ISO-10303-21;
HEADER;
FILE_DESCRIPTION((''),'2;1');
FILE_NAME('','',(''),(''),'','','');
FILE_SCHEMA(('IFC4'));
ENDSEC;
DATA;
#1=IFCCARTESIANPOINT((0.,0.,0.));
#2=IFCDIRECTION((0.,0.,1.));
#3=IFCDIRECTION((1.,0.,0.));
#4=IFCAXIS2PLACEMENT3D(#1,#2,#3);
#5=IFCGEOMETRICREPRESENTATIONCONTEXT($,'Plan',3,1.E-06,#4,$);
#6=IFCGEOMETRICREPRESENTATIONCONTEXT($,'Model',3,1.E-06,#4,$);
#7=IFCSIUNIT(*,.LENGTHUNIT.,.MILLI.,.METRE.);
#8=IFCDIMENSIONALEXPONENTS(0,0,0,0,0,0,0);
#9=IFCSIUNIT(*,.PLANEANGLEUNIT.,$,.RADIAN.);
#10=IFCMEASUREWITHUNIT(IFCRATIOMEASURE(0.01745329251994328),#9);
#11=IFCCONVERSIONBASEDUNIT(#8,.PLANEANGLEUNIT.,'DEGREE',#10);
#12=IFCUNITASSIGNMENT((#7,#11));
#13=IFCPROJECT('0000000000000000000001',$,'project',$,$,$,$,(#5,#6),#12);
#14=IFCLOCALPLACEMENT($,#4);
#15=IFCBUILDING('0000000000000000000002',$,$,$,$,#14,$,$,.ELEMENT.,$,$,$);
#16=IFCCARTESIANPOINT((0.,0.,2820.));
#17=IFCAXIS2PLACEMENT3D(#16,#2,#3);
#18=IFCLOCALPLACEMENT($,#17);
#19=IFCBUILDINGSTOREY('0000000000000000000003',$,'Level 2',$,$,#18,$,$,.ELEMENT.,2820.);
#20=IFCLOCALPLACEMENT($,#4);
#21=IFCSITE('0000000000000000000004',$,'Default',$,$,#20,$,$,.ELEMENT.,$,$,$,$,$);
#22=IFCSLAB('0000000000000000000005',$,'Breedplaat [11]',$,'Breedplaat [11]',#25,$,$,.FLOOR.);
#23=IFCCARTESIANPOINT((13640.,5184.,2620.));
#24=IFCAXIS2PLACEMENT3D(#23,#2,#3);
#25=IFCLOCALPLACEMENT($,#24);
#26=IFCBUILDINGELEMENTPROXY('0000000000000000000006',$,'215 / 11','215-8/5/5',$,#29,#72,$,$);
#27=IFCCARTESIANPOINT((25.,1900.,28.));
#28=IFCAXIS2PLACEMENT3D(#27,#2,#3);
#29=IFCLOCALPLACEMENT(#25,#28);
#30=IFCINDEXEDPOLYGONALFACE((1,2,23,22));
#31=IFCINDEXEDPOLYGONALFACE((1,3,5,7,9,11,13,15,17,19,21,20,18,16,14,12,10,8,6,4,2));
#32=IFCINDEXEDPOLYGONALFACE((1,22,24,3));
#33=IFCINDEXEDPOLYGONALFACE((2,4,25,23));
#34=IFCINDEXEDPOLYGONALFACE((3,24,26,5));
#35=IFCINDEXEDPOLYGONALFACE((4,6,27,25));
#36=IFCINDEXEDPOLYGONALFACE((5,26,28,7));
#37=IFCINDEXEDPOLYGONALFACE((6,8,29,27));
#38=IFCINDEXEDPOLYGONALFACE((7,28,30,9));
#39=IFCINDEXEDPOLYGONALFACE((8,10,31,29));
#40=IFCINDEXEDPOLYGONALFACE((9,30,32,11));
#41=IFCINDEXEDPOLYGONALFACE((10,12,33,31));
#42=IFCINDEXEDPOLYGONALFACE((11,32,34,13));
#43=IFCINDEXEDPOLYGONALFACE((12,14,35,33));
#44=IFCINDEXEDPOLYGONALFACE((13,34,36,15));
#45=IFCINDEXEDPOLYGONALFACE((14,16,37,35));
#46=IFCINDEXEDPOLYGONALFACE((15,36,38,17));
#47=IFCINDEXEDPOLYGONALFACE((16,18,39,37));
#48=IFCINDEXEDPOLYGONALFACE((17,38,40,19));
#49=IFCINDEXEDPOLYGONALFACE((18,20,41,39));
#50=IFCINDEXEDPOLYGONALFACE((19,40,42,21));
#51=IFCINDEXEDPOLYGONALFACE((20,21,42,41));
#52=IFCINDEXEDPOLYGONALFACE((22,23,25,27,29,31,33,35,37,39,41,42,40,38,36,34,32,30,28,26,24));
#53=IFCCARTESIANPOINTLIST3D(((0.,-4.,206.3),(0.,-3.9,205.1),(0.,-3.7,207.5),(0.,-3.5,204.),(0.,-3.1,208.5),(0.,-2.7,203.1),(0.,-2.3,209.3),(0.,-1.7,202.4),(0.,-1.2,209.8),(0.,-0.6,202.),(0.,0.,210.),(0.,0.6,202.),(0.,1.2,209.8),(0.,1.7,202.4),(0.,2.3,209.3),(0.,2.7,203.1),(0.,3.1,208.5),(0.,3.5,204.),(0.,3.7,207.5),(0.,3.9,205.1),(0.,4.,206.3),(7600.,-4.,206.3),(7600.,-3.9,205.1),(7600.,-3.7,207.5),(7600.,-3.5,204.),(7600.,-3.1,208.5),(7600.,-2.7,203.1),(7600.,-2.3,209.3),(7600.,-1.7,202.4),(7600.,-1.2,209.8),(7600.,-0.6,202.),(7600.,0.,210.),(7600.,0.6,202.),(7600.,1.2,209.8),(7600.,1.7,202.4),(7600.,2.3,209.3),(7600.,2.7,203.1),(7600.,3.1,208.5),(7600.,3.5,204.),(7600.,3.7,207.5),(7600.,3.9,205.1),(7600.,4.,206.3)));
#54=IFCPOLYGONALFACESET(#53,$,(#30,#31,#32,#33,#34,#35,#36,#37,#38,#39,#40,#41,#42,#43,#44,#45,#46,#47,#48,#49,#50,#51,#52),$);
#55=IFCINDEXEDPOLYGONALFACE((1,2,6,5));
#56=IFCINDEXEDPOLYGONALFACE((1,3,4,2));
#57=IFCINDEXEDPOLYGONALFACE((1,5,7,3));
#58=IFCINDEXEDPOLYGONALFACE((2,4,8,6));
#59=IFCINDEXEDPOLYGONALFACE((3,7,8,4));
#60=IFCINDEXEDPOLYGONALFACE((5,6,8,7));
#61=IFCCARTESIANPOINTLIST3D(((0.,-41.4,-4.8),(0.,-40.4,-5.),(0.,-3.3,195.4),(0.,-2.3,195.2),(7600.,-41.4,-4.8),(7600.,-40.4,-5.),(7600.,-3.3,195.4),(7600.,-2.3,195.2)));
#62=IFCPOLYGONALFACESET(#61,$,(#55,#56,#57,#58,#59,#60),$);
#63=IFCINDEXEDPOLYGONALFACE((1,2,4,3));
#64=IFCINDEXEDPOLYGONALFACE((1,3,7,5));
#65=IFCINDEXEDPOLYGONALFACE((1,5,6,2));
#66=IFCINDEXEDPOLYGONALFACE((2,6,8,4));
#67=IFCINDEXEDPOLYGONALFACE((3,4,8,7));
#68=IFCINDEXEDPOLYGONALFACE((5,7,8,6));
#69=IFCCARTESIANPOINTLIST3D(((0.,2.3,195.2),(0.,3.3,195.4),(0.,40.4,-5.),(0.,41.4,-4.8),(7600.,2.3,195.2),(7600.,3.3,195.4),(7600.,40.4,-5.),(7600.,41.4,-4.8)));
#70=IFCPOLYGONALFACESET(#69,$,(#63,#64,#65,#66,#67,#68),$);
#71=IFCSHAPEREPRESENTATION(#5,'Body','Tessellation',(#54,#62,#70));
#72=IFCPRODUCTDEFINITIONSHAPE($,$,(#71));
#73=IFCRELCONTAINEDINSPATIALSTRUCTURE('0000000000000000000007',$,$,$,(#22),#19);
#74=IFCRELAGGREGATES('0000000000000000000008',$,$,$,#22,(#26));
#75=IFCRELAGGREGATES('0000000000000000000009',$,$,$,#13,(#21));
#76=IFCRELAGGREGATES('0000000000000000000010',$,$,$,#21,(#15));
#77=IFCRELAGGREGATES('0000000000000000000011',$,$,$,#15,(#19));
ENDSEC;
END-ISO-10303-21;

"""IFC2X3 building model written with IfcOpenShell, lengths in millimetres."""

from ifc_helpers import new_model, entity, si_unit, converted_unit, frame, origin_with_axes, origin_2d_with_axis, place, context, project, spatial, rectangle, circle, extrude, element, aggregate, save


model = new_model("IFC2X3")

# Units and contexts
plan_context = context("Plan", 3, precision=1e-06, world=origin_with_axes())
model_context = context("Model", 3, precision=1e-06, world=origin_with_axes())
ifc_project = project(units=[si_unit("LENGTHUNIT", "METRE", prefix="MILLI"), converted_unit("PLANEANGLEUNIT", "DEGREE", entity("IfcRatioMeasure", 0.01745329251994328), si_unit("PLANEANGLEUNIT", "RADIAN"), dimensions=[0, 0, 0, 0, 0, 0, 0])], contexts=[plan_context, model_context])

# Site, building, storey
site_placement = place(None, origin_with_axes())
site = spatial("IfcSite", under=ifc_project, at=site_placement, Name="Default", CompositionType="ELEMENT")
building_placement = place(None, origin_with_axes())
building = spatial("IfcBuilding", under=site, at=building_placement, CompositionType="ELEMENT")
storey_placement = place(None, frame((0.0, 0.0, 2820.0), z_axis=(0.0, 0.0, 1.0), x_axis=(1.0, 0.0, 0.0)))
storey = spatial("IfcBuildingStorey", under=building, at=storey_placement, Name="Level 2", CompositionType="ELEMENT", Elevation=2820.0)

# Slab, building element proxy
slab_1_placement = place(None, frame((13640.0, 5184.0, 2620.0), z_axis=(0.0, 0.0, 1.0), x_axis=(1.0, 0.0, 0.0)))
slab_1 = element("IfcSlab", 1, at=slab_1_placement, inside=storey, Name="Breedplaat [11]", ObjectType="Breedplaat [11]", PredefinedType="FLOOR")
proxy_1_placement = place(slab_1_placement, frame((25.0, 1900.0, 28.0), z_axis=(0.0, 0.0, 1.0), x_axis=(1.0, 0.0, 0.0)))
proxy_1 = element("IfcBuildingElementProxy", 2, at=proxy_1_placement, Name="215 / 11", Description="215-8/5/5", context=plan_context, shape_type="SweptSolid", body=[
    extrude(circle(Radius=4.0, at=origin_2d_with_axis()), frame((0.0, 0.0, 206.0), z_axis=(1.0, 0.0, 0.0), x_axis=(0.0, 0.0, 1.0)), (0.0, 0.0, 1.0), 7600.0),
    extrude(rectangle(XDim=203.8, YDim=1.0, at=origin_2d_with_axis()), frame((0.0, -21.9, 95.2), z_axis=(1.0, 0.0, 0.0), x_axis=(0.0, 0.187112, 0.982339)), (0.0, 0.0, 1.0), 7600.0),
    extrude(rectangle(XDim=203.8, YDim=1.0, at=origin_2d_with_axis()), frame((0.0, 21.9, 95.2), z_axis=(1.0, 0.0, 0.0), x_axis=(0.0, -0.187112, 0.982339)), (0.0, 0.0, 1.0), 7600.0),
])
aggregate(slab_1, [proxy_1])

save(model, "model.ifc")
